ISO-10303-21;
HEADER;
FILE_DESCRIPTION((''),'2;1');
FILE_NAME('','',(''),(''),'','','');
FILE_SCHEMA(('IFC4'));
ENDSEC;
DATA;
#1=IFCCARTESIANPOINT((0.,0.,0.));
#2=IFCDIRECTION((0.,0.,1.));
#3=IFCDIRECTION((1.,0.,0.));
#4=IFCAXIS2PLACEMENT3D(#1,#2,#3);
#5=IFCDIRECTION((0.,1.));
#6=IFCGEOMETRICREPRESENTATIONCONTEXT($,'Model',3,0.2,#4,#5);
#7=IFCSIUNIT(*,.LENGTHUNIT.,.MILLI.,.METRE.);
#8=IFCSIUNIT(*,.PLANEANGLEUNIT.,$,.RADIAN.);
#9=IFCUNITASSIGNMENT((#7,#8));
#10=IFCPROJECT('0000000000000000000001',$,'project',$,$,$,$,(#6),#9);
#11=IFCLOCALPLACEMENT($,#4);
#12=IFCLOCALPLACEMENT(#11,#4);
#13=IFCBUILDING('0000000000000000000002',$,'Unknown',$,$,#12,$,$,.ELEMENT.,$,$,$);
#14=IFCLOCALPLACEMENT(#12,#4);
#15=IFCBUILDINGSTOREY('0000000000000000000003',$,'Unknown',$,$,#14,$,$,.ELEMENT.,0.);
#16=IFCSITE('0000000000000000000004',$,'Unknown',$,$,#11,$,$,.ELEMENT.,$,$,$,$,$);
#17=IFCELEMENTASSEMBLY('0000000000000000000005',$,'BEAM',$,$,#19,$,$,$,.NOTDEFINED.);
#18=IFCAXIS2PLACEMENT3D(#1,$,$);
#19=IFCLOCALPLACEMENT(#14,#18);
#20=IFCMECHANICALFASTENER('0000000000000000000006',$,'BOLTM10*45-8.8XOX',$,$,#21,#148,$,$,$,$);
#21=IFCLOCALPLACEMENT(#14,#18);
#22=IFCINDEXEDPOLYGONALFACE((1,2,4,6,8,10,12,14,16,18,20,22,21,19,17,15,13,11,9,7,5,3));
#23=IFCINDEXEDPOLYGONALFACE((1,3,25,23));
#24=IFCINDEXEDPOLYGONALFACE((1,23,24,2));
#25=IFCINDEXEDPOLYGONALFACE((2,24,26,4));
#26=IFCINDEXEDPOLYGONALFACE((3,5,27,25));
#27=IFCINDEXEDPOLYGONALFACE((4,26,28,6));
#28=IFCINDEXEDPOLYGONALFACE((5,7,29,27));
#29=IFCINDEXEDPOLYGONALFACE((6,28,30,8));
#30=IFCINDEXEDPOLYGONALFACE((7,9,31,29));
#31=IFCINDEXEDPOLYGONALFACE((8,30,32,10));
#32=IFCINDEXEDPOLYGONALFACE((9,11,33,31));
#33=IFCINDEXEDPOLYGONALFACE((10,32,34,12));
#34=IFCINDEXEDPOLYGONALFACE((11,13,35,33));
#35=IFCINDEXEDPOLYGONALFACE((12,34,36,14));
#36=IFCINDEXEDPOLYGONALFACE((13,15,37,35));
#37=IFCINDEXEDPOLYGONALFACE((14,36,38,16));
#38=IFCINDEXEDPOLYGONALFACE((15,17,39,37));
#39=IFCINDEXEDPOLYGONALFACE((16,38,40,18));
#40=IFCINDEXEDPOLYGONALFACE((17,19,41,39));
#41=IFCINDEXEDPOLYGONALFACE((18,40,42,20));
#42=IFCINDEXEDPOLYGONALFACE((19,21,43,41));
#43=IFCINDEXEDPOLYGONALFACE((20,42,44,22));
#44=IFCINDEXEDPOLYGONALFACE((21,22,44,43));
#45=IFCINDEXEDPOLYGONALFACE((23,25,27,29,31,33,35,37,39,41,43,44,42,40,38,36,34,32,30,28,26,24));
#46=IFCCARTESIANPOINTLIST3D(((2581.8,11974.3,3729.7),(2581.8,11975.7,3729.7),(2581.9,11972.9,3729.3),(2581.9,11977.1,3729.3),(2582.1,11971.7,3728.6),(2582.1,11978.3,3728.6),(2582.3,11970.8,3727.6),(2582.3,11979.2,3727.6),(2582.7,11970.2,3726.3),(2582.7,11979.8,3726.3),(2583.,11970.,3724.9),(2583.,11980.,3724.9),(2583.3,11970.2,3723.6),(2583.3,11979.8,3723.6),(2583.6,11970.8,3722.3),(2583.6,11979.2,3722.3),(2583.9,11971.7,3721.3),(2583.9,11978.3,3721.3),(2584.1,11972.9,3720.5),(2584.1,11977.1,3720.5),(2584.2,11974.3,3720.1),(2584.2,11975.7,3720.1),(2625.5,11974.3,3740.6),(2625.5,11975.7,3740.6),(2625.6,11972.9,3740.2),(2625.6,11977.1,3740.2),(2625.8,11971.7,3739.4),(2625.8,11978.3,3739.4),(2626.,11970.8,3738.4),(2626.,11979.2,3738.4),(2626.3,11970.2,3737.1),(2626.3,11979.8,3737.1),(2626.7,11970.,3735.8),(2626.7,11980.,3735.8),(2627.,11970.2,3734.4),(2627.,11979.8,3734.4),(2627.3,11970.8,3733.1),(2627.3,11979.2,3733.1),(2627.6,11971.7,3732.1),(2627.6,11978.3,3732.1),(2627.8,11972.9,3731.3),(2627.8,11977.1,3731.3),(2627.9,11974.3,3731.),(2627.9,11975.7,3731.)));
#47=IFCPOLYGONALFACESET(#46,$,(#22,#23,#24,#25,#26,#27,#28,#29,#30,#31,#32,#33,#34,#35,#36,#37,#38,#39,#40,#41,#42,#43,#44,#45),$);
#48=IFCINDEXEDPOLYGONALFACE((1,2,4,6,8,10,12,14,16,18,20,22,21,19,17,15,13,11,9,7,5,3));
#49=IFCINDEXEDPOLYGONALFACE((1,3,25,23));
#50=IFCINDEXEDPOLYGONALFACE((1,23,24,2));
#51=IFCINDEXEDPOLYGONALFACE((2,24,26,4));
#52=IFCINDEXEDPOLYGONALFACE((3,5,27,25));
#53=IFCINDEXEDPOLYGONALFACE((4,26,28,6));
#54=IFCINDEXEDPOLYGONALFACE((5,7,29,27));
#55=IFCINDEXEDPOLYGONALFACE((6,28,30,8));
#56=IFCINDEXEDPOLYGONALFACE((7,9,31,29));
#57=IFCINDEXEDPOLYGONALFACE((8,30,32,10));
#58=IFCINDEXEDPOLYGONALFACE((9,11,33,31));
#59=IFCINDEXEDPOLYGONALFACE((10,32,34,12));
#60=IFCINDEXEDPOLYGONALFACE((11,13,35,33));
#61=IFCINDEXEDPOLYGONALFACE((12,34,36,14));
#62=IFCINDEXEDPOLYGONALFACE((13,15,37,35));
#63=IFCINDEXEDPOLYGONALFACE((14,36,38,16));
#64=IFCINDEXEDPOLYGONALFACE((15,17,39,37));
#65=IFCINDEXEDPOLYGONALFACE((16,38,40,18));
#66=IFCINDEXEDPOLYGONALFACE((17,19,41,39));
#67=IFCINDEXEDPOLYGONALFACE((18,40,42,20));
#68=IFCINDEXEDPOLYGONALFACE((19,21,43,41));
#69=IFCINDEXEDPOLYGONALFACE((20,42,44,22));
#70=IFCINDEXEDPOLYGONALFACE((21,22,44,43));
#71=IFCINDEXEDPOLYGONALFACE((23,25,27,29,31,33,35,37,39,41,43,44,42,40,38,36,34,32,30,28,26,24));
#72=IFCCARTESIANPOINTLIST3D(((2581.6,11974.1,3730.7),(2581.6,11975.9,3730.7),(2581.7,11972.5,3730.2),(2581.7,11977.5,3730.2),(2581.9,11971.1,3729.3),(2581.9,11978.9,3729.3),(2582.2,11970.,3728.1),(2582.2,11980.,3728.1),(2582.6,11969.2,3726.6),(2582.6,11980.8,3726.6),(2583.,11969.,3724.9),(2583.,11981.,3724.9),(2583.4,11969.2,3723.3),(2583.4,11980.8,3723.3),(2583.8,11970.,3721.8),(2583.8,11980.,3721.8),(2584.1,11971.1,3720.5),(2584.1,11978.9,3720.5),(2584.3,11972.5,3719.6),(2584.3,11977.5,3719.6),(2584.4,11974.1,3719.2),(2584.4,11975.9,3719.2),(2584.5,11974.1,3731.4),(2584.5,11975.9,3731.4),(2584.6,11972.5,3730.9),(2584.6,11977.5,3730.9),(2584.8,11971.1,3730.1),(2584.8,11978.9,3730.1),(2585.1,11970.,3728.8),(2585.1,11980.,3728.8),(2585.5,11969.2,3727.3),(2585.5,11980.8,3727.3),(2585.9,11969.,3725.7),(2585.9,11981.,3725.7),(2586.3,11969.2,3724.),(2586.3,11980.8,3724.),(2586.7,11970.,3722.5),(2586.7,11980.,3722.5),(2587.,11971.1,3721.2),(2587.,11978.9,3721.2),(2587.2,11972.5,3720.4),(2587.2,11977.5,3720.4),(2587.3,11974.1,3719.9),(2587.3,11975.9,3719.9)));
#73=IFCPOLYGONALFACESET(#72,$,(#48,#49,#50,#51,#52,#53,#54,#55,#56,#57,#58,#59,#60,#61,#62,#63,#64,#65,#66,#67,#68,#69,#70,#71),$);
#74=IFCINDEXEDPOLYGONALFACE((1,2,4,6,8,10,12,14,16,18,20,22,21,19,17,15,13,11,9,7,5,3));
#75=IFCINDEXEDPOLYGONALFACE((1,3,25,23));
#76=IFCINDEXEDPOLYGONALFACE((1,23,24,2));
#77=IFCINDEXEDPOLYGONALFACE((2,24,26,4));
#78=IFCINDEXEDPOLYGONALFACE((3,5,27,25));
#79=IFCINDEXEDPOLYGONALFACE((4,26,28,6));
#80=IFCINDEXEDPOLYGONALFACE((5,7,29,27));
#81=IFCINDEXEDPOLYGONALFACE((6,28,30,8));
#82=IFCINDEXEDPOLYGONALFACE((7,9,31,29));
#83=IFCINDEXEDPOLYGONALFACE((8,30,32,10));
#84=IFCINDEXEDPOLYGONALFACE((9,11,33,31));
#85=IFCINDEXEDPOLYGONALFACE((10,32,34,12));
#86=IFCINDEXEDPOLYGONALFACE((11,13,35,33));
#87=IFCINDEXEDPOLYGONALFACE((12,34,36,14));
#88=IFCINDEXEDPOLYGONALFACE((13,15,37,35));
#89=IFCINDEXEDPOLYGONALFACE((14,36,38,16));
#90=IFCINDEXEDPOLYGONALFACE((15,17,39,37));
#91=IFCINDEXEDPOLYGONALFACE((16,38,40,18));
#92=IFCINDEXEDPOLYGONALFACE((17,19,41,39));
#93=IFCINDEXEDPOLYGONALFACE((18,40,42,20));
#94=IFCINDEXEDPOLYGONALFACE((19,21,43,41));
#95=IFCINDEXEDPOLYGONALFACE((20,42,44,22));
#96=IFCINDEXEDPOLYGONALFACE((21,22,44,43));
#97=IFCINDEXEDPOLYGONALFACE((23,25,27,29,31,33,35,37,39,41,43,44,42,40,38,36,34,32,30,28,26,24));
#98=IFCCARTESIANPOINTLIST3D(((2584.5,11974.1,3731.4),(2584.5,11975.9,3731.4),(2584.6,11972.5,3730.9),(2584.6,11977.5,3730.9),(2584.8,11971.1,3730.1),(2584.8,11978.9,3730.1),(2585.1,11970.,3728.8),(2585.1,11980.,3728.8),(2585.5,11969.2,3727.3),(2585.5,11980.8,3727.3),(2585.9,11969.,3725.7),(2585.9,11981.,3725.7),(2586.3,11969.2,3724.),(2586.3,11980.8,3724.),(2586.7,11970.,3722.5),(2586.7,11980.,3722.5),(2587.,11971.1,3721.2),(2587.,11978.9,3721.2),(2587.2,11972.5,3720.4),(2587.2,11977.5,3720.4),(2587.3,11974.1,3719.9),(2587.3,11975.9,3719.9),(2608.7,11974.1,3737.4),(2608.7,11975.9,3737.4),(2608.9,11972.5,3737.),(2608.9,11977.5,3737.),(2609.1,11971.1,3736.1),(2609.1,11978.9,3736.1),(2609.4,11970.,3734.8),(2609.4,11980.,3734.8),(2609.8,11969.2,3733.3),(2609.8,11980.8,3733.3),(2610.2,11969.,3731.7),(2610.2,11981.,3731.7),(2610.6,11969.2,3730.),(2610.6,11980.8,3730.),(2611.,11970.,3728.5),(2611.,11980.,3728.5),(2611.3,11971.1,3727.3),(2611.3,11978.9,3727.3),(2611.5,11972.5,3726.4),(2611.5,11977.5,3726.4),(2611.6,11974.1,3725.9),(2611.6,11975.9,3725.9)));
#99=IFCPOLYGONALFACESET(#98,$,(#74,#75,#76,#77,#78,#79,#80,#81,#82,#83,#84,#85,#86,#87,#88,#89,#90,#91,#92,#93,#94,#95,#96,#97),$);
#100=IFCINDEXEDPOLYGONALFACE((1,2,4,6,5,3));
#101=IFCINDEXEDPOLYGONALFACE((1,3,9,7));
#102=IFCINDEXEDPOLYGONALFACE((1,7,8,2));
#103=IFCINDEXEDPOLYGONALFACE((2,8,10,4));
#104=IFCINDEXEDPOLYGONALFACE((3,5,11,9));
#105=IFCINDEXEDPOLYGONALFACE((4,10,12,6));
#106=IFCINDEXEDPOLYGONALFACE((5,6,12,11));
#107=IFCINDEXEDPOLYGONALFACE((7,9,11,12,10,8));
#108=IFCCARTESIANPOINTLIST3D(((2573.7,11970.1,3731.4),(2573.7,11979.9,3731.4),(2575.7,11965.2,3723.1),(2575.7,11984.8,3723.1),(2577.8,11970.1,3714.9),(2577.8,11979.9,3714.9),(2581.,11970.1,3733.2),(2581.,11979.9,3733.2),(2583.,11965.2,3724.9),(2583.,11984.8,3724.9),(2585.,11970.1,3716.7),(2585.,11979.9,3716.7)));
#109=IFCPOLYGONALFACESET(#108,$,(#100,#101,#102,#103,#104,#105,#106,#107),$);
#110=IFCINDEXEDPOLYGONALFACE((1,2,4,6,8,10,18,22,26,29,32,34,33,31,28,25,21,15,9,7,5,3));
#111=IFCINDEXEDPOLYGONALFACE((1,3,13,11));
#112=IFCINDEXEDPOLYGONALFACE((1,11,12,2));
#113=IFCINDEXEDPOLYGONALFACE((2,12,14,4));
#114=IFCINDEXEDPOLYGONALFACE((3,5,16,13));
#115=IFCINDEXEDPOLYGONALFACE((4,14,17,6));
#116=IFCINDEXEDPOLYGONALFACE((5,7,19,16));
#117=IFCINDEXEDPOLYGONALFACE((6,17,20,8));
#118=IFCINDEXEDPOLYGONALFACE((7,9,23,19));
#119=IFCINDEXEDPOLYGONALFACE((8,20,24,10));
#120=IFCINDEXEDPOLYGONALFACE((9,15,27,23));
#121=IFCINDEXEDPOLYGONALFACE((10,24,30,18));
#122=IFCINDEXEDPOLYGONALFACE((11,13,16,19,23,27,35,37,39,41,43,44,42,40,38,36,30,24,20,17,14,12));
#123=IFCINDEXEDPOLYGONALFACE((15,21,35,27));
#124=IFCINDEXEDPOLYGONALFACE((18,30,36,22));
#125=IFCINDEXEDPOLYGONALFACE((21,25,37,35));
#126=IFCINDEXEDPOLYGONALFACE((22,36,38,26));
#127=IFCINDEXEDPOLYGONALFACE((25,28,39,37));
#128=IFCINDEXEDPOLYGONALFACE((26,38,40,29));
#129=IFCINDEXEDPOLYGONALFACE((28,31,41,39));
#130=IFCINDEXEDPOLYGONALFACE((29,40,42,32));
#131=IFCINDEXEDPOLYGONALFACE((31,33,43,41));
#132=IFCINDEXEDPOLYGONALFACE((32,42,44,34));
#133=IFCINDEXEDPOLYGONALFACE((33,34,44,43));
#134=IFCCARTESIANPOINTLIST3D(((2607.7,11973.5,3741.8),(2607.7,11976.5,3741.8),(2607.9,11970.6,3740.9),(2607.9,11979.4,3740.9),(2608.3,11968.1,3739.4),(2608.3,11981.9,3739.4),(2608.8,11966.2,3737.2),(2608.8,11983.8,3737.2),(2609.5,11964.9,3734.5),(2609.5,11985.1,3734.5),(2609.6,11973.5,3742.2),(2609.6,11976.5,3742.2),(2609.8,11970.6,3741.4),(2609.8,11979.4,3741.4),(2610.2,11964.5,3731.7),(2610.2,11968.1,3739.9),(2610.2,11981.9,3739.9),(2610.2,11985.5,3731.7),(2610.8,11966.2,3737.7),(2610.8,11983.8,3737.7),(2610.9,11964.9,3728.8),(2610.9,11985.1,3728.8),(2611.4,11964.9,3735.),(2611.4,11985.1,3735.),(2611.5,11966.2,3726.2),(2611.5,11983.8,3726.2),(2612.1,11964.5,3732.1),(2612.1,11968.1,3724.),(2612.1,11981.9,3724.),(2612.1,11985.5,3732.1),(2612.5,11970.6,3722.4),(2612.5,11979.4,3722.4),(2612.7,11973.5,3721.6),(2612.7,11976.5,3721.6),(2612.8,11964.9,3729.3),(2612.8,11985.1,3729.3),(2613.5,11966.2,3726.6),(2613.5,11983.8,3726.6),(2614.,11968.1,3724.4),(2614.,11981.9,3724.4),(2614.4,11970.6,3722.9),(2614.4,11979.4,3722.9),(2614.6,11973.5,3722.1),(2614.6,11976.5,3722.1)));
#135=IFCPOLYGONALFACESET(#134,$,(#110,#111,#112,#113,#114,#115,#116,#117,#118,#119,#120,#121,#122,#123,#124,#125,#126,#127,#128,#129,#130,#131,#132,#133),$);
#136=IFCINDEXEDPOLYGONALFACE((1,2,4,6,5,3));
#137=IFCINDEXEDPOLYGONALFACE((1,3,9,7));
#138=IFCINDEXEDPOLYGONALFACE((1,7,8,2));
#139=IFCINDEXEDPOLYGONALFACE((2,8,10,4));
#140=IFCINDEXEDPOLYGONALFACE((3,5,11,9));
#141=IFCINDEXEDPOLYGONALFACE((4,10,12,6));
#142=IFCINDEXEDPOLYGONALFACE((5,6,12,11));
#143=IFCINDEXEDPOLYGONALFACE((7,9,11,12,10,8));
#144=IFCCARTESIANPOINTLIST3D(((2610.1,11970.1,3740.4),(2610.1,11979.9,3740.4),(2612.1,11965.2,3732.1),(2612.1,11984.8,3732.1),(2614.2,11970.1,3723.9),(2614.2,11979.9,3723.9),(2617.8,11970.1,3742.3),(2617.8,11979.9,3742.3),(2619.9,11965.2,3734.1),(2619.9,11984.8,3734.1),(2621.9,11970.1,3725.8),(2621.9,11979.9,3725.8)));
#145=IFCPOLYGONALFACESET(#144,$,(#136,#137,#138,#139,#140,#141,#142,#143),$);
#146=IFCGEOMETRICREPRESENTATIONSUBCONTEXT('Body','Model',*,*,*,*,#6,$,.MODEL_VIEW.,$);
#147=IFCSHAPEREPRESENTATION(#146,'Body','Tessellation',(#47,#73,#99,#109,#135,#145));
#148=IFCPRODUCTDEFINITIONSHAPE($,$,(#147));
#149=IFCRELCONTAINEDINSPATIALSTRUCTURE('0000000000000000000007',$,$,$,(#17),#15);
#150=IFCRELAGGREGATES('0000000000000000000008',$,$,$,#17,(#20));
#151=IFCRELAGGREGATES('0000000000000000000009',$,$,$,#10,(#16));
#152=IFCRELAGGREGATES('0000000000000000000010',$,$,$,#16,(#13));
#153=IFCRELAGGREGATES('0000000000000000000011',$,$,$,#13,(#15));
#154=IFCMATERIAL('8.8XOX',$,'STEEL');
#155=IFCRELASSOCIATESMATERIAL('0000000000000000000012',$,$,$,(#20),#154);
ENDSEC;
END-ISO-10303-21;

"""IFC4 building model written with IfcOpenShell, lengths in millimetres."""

from ifc_helpers import new_model, si_unit, direction, frame, origin_with_axes, place, context, subcontext, project, spatial, line, arc, indexed_curve, outline, extrude, source, transform, mapped, material, element, aggregate, save


model = new_model("IFC4")

# Units and contexts
model_context = context("Model", 3, precision=0.2, world=origin_with_axes(), true_north=direction((0.0, 1.0)))
body_context = subcontext(model_context, "Body", "Model", "MODEL_VIEW")
ifc_project = project(units=[si_unit("LENGTHUNIT", "METRE", prefix="MILLI"), si_unit("PLANEANGLEUNIT", "RADIAN")], contexts=[model_context])

# Site, building, storey
site_placement = place(None, origin_with_axes())
site = spatial("IfcSite", under=ifc_project, at=site_placement, Name="Unknown", CompositionType="ELEMENT")
building_placement = place(site_placement, origin_with_axes())
building = spatial("IfcBuilding", under=site, at=building_placement, Name="Unknown", CompositionType="ELEMENT")
storey_placement = place(building_placement, origin_with_axes())
storey = spatial("IfcBuildingStorey", under=building, at=storey_placement, Name="Unknown", CompositionType="ELEMENT", Elevation=0.0)

# Shared definitions
ifc_material_1 = material(Name="8.8XOX", Category="STEEL")

# Element assembly, mechanical fastener
shared_shape_1 = source(origin_with_axes(), body_context, "Body", "SweptSolid", [
    extrude(outline(indexed_curve([(5.0, 0.0), (0.0, 5.0), (-5.0, 0.0), (0.0, -5.0)], segments=[arc(1, 2, 3), arc(3, 4, 1)])), frame((0.0, 0.0, 3.8), z_axis=(0.0, 0.0, -1.0), x_axis=(0.0, 1.0, 0.0)), (0.0, 0.0, 1.0), 45.0),
    extrude(outline(indexed_curve([(6.0, 0.0), (0.0, 6.0), (-6.0, 0.0), (0.0, -6.0)], segments=[arc(1, 2, 3), arc(3, 4, 1)])), frame((0.0, 0.0, 3.8), z_axis=(0.0, 0.0, -1.0), x_axis=(0.0, 1.0, 0.0)), (0.0, 0.0, 1.0), 3.0),
    extrude(outline(indexed_curve([(6.0, 0.0), (0.0, 6.0), (-6.0, 0.0), (0.0, -6.0)], segments=[arc(1, 2, 3), arc(3, 4, 1)])), frame((0.0, 0.0, 0.8), z_axis=(0.0, 0.0, -1.0), x_axis=(0.0, 1.0, 0.0)), (0.0, 0.0, 1.0), 25.0),
    extrude(outline(indexed_curve([(9.8, 0.0), (4.9, 8.5), (-4.9, 8.5), (-9.8, 0.0), (-4.9, -8.5), (4.9, -8.5)], segments=[line(1, 2, 3, 4, 5, 6, 1)])), frame((0.0, 0.0, 11.2), z_axis=(0.0, 0.0, -1.0), x_axis=(0.0, 1.0, 0.0)), (0.0, 0.0, 1.0), 7.5),
    extrude(outline(indexed_curve([(10.5, 0.0), (0.0, 10.5), (-10.5, 0.0), (0.0, -10.5)], segments=[arc(1, 2, 3), arc(3, 4, 1)])), frame((0.0, 0.0, -24.2), z_axis=(0.0, 0.0, -1.0), x_axis=(0.0, 1.0, 0.0)), (0.0, 0.0, 1.0), 2.0),
    extrude(outline(indexed_curve([(9.8, 0.0), (4.9, 8.5), (-4.9, 8.5), (-9.8, 0.0), (-4.9, -8.5), (4.9, -8.5)], segments=[line(1, 2, 3, 4, 5, 6, 1)])), frame((0.0, 0.0, -26.2), z_axis=(0.0, 0.0, -1.0), x_axis=(0.0, 1.0, 0.0)), (0.0, 0.0, 1.0), 8.0),
])
assembly_1_placement = place(storey_placement, frame((2596.8, 6000.0, 3733.5), z_axis=(0.970613, 0.0, 0.240648), x_axis=(0.0, 1.0, 0.0)))
assembly_1 = element("IfcElementAssembly", 1, at=assembly_1_placement, inside=storey, Name="BEAM", PredefinedType="NOTDEFINED")
mechanical_fastener_1_placement = place(assembly_1_placement, frame((5975.0, -5.0, -11.8), z_axis=(0.0, 0.0, -1.0), x_axis=(0.0, 1.0, 0.0)))
mechanical_fastener_1 = element("IfcMechanicalFastener", 2, at=mechanical_fastener_1_placement, material=ifc_material_1, Name="BOLTM10*45-8.8XOX", context=body_context, shape_type="MappedRepresentation", body=[
    mapped(shared_shape_1, transform((0.0, 0.0, 0.0))),
])
aggregate(assembly_1, [mechanical_fastener_1])

save(model, "model.ifc")
